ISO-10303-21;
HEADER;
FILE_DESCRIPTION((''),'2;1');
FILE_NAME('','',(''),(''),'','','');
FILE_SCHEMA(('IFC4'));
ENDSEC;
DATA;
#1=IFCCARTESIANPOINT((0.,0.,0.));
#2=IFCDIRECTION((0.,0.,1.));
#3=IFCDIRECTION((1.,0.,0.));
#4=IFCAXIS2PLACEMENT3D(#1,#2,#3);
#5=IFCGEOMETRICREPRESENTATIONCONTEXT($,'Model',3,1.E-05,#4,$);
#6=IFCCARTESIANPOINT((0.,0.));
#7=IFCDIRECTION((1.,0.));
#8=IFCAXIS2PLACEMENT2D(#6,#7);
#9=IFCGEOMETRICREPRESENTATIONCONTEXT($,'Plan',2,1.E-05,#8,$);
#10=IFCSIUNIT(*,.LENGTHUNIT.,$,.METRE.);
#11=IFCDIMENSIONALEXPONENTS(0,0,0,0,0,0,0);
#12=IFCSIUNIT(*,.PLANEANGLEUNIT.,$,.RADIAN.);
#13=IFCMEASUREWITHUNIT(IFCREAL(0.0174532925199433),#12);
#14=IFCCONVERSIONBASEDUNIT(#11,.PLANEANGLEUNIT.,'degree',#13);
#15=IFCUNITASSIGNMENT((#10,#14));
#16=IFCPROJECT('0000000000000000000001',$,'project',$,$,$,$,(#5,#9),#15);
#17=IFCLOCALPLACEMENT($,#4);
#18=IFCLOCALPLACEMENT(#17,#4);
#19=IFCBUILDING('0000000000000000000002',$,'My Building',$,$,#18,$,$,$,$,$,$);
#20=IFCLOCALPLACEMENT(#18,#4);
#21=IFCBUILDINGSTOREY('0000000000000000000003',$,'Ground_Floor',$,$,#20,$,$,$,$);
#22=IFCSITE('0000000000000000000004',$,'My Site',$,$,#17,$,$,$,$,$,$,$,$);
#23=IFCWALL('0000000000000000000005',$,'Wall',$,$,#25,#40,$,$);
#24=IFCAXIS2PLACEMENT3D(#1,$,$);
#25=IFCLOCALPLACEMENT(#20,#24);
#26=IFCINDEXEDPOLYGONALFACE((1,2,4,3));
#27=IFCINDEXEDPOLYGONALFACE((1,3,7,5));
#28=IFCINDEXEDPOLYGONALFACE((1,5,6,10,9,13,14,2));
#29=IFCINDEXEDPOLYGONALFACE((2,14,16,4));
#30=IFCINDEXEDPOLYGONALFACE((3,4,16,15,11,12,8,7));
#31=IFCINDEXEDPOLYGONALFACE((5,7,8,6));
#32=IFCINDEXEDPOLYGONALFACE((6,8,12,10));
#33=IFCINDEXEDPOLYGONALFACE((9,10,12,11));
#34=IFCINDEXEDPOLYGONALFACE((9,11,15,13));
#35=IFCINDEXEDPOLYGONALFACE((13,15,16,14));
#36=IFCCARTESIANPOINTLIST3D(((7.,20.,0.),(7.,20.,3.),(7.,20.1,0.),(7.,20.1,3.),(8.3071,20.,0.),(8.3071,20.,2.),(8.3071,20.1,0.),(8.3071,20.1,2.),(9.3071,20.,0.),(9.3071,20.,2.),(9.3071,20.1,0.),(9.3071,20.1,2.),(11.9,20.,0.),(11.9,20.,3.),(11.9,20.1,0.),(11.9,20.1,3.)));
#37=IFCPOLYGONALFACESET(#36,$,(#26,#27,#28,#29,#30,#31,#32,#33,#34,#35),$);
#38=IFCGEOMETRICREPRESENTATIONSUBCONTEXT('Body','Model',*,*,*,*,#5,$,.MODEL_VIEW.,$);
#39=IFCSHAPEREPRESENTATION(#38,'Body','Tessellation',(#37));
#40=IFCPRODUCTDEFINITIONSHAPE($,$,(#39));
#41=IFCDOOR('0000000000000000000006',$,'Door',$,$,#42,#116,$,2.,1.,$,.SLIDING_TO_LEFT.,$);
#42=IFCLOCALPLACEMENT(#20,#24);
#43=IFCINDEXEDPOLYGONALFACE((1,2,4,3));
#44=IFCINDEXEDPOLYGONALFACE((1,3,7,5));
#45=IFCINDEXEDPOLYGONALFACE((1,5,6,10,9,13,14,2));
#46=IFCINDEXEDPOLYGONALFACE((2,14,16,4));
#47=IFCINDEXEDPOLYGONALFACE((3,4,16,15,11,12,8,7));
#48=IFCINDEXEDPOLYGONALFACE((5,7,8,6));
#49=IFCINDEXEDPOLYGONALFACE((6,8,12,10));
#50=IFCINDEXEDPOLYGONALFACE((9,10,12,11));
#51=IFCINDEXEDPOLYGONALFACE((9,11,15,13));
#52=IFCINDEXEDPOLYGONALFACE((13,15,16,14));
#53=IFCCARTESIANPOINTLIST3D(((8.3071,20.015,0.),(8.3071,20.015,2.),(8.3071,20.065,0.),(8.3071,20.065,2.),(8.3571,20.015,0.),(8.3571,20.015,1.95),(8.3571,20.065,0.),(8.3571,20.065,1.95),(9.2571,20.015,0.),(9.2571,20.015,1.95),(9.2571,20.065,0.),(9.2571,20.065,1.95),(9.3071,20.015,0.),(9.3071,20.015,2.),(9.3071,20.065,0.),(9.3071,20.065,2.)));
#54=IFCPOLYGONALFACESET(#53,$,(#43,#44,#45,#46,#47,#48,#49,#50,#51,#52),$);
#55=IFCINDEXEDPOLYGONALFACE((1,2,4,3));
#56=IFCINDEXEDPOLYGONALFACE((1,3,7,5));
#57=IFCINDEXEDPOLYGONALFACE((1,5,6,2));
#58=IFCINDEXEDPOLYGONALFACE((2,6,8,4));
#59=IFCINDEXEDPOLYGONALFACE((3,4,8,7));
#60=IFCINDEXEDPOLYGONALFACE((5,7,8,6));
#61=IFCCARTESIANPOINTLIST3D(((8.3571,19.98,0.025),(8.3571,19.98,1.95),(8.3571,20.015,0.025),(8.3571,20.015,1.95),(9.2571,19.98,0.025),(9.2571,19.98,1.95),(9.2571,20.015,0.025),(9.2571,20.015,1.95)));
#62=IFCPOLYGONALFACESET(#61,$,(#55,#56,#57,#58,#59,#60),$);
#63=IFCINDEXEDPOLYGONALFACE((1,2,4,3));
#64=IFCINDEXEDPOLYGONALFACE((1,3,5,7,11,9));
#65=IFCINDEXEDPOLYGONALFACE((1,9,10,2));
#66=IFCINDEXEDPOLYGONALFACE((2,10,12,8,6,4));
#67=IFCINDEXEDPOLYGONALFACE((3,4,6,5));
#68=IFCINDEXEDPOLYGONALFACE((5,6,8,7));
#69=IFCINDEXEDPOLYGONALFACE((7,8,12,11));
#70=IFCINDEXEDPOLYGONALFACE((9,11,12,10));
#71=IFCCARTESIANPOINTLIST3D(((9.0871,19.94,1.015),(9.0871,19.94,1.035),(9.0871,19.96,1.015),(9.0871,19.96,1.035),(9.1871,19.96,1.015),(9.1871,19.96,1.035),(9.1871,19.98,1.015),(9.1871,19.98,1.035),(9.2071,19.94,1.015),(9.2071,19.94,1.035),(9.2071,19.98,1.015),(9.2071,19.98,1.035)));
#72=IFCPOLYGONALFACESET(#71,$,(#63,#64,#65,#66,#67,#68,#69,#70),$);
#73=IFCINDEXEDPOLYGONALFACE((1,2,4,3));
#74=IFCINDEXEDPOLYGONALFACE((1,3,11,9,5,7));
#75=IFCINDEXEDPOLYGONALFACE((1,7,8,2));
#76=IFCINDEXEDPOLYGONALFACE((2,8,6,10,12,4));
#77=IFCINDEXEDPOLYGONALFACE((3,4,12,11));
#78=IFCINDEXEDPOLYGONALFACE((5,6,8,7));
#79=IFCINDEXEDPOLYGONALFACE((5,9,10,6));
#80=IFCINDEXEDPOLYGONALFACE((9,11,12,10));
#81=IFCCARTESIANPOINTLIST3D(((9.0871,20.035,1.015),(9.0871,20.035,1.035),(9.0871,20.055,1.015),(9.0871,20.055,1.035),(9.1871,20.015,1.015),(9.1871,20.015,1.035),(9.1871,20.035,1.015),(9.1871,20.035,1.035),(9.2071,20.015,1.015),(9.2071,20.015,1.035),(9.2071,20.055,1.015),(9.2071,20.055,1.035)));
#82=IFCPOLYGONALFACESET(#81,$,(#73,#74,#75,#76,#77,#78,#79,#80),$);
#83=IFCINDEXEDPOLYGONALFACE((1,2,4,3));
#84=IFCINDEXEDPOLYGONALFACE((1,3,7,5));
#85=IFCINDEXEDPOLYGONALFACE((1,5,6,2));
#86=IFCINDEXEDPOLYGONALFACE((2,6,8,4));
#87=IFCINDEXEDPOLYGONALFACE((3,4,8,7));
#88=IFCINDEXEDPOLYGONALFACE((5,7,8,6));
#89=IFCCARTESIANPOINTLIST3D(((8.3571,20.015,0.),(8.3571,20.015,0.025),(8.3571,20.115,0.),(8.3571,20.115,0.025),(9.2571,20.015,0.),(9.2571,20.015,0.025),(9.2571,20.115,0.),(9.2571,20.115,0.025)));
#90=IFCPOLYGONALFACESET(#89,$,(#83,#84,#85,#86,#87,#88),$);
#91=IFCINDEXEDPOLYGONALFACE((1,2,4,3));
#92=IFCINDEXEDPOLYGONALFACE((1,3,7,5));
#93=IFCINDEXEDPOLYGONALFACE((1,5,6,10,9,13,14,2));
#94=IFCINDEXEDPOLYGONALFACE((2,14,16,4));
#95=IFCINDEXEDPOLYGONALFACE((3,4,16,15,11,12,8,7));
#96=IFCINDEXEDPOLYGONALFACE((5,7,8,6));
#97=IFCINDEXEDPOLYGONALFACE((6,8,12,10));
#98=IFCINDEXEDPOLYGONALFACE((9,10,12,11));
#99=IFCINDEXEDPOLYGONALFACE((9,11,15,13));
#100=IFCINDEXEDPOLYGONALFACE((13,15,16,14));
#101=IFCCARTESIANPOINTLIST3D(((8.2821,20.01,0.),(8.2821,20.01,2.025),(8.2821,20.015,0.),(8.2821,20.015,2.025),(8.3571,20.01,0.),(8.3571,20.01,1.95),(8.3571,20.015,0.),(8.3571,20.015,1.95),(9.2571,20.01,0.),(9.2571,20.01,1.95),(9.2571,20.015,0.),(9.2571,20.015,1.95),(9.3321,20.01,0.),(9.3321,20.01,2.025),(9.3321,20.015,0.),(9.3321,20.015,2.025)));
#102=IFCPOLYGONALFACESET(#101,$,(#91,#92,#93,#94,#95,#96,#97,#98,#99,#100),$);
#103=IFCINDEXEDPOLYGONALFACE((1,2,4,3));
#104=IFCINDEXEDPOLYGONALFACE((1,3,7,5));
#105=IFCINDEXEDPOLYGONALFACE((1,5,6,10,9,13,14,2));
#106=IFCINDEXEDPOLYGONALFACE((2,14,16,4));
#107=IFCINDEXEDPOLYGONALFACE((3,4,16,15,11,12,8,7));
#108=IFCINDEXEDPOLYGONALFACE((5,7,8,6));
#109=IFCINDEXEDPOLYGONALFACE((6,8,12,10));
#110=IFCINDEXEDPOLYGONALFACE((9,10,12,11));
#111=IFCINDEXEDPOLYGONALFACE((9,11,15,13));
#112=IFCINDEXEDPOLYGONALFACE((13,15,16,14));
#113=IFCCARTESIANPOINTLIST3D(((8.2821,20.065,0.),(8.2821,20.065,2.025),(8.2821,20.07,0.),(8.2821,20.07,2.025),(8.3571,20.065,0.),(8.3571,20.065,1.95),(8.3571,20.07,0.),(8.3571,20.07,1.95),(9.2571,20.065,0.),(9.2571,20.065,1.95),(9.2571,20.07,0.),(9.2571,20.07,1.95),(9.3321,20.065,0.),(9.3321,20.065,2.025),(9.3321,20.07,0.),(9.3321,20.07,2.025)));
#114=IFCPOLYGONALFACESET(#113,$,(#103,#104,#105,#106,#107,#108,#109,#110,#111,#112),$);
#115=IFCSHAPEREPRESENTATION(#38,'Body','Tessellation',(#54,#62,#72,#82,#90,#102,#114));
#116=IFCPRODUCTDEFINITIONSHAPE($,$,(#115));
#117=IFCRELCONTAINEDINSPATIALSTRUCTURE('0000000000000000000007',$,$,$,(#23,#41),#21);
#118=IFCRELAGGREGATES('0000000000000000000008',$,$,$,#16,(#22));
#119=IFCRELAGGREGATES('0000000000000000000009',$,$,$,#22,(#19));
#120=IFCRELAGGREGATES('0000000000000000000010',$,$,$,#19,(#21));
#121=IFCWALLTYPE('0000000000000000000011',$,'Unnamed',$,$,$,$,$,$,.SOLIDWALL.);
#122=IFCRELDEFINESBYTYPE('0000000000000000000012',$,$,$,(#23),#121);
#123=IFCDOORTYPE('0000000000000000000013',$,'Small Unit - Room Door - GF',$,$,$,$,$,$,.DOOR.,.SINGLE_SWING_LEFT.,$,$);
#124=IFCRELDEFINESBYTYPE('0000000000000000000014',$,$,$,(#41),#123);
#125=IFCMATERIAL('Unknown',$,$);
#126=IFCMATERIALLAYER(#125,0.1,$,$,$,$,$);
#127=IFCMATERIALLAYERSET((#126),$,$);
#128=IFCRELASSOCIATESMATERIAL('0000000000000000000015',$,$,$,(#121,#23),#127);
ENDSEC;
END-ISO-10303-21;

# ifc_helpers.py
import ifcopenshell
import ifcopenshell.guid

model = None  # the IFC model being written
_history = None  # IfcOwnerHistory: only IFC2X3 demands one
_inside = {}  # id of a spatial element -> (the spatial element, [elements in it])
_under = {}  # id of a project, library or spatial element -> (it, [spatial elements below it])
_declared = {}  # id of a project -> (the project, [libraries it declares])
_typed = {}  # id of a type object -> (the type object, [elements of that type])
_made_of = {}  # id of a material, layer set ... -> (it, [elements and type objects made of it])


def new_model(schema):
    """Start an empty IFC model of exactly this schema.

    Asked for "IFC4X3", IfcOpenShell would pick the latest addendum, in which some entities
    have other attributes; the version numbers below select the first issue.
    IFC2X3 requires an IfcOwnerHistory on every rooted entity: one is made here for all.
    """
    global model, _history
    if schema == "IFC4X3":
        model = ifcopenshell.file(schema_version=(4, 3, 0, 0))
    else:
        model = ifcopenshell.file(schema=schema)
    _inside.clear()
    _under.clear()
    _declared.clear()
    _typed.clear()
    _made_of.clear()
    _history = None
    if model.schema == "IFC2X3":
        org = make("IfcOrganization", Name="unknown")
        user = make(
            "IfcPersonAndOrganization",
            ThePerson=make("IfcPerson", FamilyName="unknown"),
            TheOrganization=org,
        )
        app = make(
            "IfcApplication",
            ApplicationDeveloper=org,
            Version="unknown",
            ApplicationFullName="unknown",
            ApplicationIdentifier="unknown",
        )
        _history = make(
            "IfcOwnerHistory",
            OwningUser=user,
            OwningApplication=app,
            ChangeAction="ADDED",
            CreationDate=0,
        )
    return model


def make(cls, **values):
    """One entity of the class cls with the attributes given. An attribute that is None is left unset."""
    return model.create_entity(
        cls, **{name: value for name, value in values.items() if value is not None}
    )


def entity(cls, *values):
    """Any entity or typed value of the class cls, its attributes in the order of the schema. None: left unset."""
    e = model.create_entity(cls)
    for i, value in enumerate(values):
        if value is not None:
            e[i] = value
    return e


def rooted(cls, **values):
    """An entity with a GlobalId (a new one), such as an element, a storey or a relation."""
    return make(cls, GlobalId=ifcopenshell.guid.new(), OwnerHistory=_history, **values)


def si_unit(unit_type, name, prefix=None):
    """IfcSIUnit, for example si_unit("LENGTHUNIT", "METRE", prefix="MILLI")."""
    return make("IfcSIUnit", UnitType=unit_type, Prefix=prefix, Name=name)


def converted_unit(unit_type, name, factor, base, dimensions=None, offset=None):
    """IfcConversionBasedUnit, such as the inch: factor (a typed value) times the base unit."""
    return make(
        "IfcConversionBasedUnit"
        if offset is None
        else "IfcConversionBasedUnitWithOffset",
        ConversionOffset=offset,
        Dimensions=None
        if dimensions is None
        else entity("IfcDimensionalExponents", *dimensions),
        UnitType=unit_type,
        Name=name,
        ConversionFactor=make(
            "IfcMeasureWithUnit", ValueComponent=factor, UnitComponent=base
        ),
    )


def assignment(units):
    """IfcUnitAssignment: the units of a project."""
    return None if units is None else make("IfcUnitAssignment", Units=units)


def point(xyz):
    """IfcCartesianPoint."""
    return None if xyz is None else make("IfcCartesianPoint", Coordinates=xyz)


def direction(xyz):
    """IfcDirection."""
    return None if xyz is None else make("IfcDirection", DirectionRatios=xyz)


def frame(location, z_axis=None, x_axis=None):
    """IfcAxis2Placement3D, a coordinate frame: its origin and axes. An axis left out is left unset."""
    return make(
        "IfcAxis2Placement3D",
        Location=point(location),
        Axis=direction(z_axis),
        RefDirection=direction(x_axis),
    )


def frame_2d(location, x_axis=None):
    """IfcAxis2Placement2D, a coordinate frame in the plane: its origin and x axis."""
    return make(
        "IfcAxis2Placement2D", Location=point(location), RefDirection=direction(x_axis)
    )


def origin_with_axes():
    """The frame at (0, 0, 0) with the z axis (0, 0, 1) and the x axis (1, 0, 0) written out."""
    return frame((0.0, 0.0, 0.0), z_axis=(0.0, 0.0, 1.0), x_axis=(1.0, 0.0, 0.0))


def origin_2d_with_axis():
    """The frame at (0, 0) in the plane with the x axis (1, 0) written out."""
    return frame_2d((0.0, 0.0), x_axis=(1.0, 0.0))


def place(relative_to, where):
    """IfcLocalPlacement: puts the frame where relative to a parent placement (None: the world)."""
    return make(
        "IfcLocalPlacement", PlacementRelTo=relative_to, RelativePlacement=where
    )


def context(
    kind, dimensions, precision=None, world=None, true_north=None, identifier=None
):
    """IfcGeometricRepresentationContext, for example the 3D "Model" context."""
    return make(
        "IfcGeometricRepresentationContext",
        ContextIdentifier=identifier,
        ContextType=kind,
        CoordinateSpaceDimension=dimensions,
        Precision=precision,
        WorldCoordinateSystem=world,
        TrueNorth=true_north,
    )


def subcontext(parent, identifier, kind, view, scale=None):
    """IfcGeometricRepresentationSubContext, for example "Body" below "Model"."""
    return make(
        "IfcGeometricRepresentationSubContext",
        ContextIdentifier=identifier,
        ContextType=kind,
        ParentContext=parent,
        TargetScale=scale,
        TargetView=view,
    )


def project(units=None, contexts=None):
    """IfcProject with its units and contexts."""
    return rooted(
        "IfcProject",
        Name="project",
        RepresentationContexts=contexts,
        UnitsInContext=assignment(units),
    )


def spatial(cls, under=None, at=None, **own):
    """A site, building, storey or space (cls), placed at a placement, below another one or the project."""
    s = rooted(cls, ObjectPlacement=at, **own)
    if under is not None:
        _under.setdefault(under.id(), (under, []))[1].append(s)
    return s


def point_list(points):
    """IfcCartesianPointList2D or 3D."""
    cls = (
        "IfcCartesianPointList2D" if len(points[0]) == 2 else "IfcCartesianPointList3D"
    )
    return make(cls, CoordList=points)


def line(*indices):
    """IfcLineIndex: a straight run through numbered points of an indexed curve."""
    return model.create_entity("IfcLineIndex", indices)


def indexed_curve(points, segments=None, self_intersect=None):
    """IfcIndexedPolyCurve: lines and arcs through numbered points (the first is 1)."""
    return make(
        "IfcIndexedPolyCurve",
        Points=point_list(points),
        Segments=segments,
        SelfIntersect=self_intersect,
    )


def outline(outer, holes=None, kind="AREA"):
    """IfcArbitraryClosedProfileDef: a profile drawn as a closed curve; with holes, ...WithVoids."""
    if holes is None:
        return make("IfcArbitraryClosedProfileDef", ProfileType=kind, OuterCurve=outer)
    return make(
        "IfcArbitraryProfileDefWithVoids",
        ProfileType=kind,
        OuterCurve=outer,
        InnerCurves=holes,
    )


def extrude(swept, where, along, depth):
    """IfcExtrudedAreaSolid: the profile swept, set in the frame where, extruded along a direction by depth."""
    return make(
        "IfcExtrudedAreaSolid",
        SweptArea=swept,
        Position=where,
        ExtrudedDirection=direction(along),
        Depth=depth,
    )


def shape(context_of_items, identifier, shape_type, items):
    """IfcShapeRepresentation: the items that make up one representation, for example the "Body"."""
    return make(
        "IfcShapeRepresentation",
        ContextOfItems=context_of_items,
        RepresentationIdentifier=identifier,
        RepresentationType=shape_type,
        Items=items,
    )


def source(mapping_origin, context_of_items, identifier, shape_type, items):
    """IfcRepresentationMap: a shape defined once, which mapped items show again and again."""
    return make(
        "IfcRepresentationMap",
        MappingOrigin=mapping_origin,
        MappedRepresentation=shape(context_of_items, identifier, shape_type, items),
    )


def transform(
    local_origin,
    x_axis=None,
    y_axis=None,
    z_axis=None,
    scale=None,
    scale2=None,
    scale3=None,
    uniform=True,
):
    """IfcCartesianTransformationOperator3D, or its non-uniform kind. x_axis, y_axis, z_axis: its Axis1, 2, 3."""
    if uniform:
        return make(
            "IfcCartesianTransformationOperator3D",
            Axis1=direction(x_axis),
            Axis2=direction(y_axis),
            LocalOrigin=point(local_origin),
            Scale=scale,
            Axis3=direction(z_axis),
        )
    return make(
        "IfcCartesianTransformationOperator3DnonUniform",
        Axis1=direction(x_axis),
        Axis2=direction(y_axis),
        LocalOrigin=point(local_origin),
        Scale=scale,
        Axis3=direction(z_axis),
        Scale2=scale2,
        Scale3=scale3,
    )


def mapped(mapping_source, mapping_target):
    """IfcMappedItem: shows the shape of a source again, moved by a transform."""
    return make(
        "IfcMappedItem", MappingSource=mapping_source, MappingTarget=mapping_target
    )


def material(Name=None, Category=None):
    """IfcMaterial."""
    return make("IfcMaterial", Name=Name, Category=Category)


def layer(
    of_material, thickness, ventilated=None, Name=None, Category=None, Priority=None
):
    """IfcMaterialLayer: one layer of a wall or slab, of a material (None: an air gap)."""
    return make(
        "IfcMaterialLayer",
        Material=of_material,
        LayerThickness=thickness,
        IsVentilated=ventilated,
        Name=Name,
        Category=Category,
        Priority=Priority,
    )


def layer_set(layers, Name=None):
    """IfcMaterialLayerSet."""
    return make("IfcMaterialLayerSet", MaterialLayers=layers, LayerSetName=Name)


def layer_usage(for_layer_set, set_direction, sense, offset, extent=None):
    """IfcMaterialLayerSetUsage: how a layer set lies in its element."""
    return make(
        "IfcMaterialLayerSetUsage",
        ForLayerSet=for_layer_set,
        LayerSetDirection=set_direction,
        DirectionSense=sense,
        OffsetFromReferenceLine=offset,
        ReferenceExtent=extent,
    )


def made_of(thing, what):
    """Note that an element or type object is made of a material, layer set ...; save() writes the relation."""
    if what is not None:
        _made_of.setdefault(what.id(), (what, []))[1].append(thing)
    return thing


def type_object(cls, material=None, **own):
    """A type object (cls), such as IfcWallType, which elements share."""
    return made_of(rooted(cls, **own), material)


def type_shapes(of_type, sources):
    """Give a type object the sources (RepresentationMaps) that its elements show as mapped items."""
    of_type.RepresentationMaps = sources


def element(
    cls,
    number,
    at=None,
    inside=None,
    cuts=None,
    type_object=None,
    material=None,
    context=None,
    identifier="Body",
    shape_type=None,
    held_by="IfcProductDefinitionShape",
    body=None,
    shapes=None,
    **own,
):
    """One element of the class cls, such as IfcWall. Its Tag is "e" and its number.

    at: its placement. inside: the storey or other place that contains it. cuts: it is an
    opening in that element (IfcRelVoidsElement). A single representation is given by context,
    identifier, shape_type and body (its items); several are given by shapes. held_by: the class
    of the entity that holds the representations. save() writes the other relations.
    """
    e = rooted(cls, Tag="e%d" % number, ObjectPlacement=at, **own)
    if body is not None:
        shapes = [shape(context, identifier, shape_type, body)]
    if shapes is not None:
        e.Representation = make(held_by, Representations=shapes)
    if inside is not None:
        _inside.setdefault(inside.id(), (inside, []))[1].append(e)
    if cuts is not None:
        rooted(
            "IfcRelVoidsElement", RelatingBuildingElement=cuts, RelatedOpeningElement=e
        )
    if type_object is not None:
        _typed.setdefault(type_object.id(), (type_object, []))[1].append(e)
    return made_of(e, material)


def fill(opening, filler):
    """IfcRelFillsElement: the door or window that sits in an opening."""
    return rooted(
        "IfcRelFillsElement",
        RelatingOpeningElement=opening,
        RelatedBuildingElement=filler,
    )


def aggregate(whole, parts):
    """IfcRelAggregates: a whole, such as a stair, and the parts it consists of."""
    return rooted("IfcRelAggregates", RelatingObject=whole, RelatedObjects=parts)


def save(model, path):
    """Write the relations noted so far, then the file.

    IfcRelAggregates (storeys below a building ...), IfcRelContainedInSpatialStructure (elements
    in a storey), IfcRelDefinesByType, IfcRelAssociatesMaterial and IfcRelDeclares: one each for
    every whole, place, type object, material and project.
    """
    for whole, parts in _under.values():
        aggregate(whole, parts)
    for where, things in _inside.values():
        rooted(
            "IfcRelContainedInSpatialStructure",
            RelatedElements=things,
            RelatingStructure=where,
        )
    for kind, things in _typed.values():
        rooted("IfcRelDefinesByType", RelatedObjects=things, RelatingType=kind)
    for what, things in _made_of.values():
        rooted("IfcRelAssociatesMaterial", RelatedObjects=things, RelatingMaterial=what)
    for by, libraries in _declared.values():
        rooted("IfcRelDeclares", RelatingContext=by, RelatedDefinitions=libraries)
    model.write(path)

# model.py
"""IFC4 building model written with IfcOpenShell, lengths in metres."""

from ifc_helpers import new_model, entity, si_unit, converted_unit, frame, origin_with_axes, origin_2d_with_axis, place, context, subcontext, project, spatial, line, indexed_curve, outline, extrude, shape, source, transform, mapped, material, layer, layer_set, layer_usage, type_object, type_shapes, element, fill, save


model = new_model("IFC4")

# Units and contexts
model_context = context("Model", 3, precision=1e-05, world=origin_with_axes())
plan_context = context("Plan", 2, precision=1e-05, world=origin_2d_with_axis())
body_context_1 = subcontext(model_context, "Body", "Model", "MODEL_VIEW")
body_context_2 = subcontext(plan_context, "Body", "Plan", "PLAN_VIEW")
ifc_project = project(units=[si_unit("LENGTHUNIT", "METRE"), converted_unit("PLANEANGLEUNIT", "degree", entity("IfcReal", 0.0174532925199433), si_unit("PLANEANGLEUNIT", "RADIAN"), dimensions=[0, 0, 0, 0, 0, 0, 0])], contexts=[model_context, plan_context])

# Site, building, storey
site_placement = place(None, origin_with_axes())
site = spatial("IfcSite", under=ifc_project, at=site_placement, Name="My Site")
building_placement = place(site_placement, origin_with_axes())
building = spatial("IfcBuilding", under=site, at=building_placement, Name="My Building")
storey_placement = place(building_placement, origin_with_axes())
storey = spatial("IfcBuildingStorey", under=building, at=storey_placement, Name="Ground_Floor")

# Shared definitions
ifc_material = material(Name="Unknown")
ifc_layer = layer(ifc_material, 0.1)
ifc_layer_set = layer_set([ifc_layer])
wall_type = type_object("IfcWallType", Name="Unnamed", PredefinedType="SOLIDWALL", material=ifc_layer_set)

# Wall, opening, door
ifc_layer_usage_1 = layer_usage(ifc_layer_set, "AXIS2", "POSITIVE", 0.0)
wall_1_placement = place(storey_placement, frame((7.0, 20.0, 0.0), z_axis=(0.0, 0.0, 1.0), x_axis=(1.0, 0.0, 0.0)))
wall_1 = element("IfcWall", 1, at=wall_1_placement, inside=storey, type_object=wall_type, material=ifc_layer_usage_1, Name="Wall", context=body_context_1, shape_type="SweptSolid", body=[
    extrude(outline(indexed_curve([(0.0, 0.0), (0.0, 0.1), (4.9, 0.1), (4.9, 0.0)], segments=[line(1, 2, 3, 4, 1)])), origin_with_axes(), (0.0, 0.0, 1.0), 3.0),
])
shared_shape_1 = source(origin_with_axes(), body_context_1, "Body", "SweptSolid", [
    extrude(outline(indexed_curve([(0.0, 0.0), (1.0, 0.0), (1.0, 2.0), (0.0, 2.0)], segments=[line(1, 2, 3, 4, 1)])), frame((0.0, -0.6, 0.0), z_axis=(0.0, -1.0, 0.0), x_axis=(1.0, 0.0, 0.0)), (0.0, 0.0, -1.0), 1.2),
])
opening_1_placement = place(wall_1_placement, frame((1.3071, 0.015, 0.0), z_axis=(0.0, 0.0, 1.0), x_axis=(1.0, 0.0, 0.0)))
opening_1 = element("IfcOpeningElement", 2, at=opening_1_placement, cuts=wall_1, PredefinedType="OPENING", context=body_context_1, shape_type="MappedRepresentation", body=[
    mapped(shared_shape_1, transform((0.0, 0.0, 0.0), x_axis=(1.0, 0.0, 0.0), y_axis=(0.0, 1.0, 0.0), z_axis=(0.0, 0.0, 1.0), scale=1.0)),
])
door_type_1 = type_object("IfcDoorType", Name="Small Unit - Room Door - GF", OperationType="SINGLE_SWING_LEFT", PredefinedType="DOOR")
shared_shape_2 = source(origin_with_axes(), body_context_1, "Body", "SweptSolid", [
    extrude(outline(indexed_curve([(0.0, 0.0), (0.0, 2.0), (1.0, 2.0), (1.0, 0.0), (0.95, 0.0), (0.95, 1.95), (0.05, 1.95), (0.05, 0.0)], segments=[line(1, 2, 3, 4, 5, 6, 7, 8, 1)])), frame((0.0, 0.0, 0.0), z_axis=(0.0, -1.0, 0.0), x_axis=(1.0, 0.0, 0.0)), (0.0, 0.0, -1.0), 0.05),
    extrude(outline(indexed_curve([(0.0, 0.0), (0.9, 0.0), (0.9, 0.035), (0.0, 0.035)], segments=[line(1, 2, 3, 4, 1)])), frame((0.05, -0.035, 0.025), z_axis=(0.0, 0.0, 1.0), x_axis=(1.0, 0.0, 0.0)), (0.0, 0.0, 1.0), 1.925),
    extrude(outline(indexed_curve([(0.0, 0.0), (0.0, -0.04), (-0.12, -0.04), (-0.12, -0.02), (-0.02, -0.02), (-0.02, 0.0)], segments=[line(1, 2, 3, 4, 5, 6, 1)])), frame((0.9, -0.035, 1.015), z_axis=(0.0, 0.0, 1.0), x_axis=(1.0, 0.0, 0.0)), (0.0, 0.0, 1.0), 0.02),
    extrude(outline(indexed_curve([(0.0, 0.0), (0.0, 0.04), (-0.12, 0.04), (-0.12, 0.02), (-0.02, 0.02), (-0.02, 0.0)], segments=[line(1, 2, 3, 4, 5, 6, 1)])), frame((0.9, 0.0, 1.015), z_axis=(0.0, 0.0, 1.0), x_axis=(1.0, 0.0, 0.0)), (0.0, 0.0, 1.0), 0.02),
    extrude(outline(indexed_curve([(0.0, 0.0), (0.9, 0.0), (0.9, 0.1), (0.0, 0.1)], segments=[line(1, 2, 3, 4, 1)])), frame((0.05, 0.0, 0.0), z_axis=(0.0, 0.0, 1.0), x_axis=(1.0, 0.0, 0.0)), (0.0, 0.0, 1.0), 0.025),
    extrude(outline(indexed_curve([(0.0, 0.0), (0.0, 2.025), (1.05, 2.025), (1.05, 0.0), (0.975, 0.0), (0.975, 1.95), (0.075, 1.95), (0.075, 0.0)], segments=[line(1, 2, 3, 4, 5, 6, 7, 8, 1)])), frame((-0.025, -0.005, 0.0), z_axis=(0.0, -1.0, 0.0), x_axis=(1.0, 0.0, 0.0)), (0.0, 0.0, -1.0), 0.005),
    extrude(outline(indexed_curve([(0.0, 0.0), (0.0, 2.025), (1.05, 2.025), (1.05, 0.0), (0.975, 0.0), (0.975, 1.95), (0.075, 1.95), (0.075, 0.0)], segments=[line(1, 2, 3, 4, 5, 6, 7, 8, 1)])), frame((-0.025, 0.05, 0.0), z_axis=(0.0, -1.0, 0.0), x_axis=(1.0, 0.0, 0.0)), (0.0, 0.0, -1.0), 0.005),
])
shared_shape_3 = source(origin_with_axes(), body_context_2, "Body", "Curve2D", [
    entity("IfcIndexedPolyCurve", entity("IfcCartesianPointList2D", [[0.0, 0.0], [0.05, 0.0], [0.05, 0.05], [0.0, 0.05]]), [entity("IfcLineIndex", [1, 2, 3, 4, 1])]),
    entity("IfcIndexedPolyCurve", entity("IfcCartesianPointList2D", [[1.0, 0.0], [0.95, 0.0], [0.95, 0.05], [1.0, 0.05]]), [entity("IfcLineIndex", [1, 2, 3, 4, 1])]),
    entity("IfcIndexedPolyCurve", entity("IfcCartesianPointList2D", [[-0.4, -0.035], [0.5, -0.035], [0.5, 0.0], [-0.4, 0.0]]), [entity("IfcLineIndex", [1, 2, 3, 4, 1])]),
])
type_shapes(door_type_1, [shared_shape_2, shared_shape_3])
door_1_placement = place(opening_1_placement, origin_with_axes())
door_1 = element("IfcDoor", 3, at=door_1_placement, inside=storey, type_object=door_type_1, Name="Door", OperationType="SLIDING_TO_LEFT", OverallHeight=2.0, OverallWidth=1.0, shapes=[
    shape(body_context_1, "Body", "MappedRepresentation", [mapped(shared_shape_2, transform((0.0, 0.0, 0.0), x_axis=(1.0, 0.0, 0.0), y_axis=(0.0, 1.0, 0.0), z_axis=(0.0, 0.0, 1.0), scale=1.0))]),
    shape(body_context_2, "Body", "MappedRepresentation", [mapped(shared_shape_3, transform((0.0, 0.0, 0.0), x_axis=(1.0, 0.0, 0.0), y_axis=(0.0, 1.0, 0.0), z_axis=(0.0, 0.0, 1.0), scale=1.0))]),
])
fill(opening_1, door_1)

save(model, "model.ifc")
